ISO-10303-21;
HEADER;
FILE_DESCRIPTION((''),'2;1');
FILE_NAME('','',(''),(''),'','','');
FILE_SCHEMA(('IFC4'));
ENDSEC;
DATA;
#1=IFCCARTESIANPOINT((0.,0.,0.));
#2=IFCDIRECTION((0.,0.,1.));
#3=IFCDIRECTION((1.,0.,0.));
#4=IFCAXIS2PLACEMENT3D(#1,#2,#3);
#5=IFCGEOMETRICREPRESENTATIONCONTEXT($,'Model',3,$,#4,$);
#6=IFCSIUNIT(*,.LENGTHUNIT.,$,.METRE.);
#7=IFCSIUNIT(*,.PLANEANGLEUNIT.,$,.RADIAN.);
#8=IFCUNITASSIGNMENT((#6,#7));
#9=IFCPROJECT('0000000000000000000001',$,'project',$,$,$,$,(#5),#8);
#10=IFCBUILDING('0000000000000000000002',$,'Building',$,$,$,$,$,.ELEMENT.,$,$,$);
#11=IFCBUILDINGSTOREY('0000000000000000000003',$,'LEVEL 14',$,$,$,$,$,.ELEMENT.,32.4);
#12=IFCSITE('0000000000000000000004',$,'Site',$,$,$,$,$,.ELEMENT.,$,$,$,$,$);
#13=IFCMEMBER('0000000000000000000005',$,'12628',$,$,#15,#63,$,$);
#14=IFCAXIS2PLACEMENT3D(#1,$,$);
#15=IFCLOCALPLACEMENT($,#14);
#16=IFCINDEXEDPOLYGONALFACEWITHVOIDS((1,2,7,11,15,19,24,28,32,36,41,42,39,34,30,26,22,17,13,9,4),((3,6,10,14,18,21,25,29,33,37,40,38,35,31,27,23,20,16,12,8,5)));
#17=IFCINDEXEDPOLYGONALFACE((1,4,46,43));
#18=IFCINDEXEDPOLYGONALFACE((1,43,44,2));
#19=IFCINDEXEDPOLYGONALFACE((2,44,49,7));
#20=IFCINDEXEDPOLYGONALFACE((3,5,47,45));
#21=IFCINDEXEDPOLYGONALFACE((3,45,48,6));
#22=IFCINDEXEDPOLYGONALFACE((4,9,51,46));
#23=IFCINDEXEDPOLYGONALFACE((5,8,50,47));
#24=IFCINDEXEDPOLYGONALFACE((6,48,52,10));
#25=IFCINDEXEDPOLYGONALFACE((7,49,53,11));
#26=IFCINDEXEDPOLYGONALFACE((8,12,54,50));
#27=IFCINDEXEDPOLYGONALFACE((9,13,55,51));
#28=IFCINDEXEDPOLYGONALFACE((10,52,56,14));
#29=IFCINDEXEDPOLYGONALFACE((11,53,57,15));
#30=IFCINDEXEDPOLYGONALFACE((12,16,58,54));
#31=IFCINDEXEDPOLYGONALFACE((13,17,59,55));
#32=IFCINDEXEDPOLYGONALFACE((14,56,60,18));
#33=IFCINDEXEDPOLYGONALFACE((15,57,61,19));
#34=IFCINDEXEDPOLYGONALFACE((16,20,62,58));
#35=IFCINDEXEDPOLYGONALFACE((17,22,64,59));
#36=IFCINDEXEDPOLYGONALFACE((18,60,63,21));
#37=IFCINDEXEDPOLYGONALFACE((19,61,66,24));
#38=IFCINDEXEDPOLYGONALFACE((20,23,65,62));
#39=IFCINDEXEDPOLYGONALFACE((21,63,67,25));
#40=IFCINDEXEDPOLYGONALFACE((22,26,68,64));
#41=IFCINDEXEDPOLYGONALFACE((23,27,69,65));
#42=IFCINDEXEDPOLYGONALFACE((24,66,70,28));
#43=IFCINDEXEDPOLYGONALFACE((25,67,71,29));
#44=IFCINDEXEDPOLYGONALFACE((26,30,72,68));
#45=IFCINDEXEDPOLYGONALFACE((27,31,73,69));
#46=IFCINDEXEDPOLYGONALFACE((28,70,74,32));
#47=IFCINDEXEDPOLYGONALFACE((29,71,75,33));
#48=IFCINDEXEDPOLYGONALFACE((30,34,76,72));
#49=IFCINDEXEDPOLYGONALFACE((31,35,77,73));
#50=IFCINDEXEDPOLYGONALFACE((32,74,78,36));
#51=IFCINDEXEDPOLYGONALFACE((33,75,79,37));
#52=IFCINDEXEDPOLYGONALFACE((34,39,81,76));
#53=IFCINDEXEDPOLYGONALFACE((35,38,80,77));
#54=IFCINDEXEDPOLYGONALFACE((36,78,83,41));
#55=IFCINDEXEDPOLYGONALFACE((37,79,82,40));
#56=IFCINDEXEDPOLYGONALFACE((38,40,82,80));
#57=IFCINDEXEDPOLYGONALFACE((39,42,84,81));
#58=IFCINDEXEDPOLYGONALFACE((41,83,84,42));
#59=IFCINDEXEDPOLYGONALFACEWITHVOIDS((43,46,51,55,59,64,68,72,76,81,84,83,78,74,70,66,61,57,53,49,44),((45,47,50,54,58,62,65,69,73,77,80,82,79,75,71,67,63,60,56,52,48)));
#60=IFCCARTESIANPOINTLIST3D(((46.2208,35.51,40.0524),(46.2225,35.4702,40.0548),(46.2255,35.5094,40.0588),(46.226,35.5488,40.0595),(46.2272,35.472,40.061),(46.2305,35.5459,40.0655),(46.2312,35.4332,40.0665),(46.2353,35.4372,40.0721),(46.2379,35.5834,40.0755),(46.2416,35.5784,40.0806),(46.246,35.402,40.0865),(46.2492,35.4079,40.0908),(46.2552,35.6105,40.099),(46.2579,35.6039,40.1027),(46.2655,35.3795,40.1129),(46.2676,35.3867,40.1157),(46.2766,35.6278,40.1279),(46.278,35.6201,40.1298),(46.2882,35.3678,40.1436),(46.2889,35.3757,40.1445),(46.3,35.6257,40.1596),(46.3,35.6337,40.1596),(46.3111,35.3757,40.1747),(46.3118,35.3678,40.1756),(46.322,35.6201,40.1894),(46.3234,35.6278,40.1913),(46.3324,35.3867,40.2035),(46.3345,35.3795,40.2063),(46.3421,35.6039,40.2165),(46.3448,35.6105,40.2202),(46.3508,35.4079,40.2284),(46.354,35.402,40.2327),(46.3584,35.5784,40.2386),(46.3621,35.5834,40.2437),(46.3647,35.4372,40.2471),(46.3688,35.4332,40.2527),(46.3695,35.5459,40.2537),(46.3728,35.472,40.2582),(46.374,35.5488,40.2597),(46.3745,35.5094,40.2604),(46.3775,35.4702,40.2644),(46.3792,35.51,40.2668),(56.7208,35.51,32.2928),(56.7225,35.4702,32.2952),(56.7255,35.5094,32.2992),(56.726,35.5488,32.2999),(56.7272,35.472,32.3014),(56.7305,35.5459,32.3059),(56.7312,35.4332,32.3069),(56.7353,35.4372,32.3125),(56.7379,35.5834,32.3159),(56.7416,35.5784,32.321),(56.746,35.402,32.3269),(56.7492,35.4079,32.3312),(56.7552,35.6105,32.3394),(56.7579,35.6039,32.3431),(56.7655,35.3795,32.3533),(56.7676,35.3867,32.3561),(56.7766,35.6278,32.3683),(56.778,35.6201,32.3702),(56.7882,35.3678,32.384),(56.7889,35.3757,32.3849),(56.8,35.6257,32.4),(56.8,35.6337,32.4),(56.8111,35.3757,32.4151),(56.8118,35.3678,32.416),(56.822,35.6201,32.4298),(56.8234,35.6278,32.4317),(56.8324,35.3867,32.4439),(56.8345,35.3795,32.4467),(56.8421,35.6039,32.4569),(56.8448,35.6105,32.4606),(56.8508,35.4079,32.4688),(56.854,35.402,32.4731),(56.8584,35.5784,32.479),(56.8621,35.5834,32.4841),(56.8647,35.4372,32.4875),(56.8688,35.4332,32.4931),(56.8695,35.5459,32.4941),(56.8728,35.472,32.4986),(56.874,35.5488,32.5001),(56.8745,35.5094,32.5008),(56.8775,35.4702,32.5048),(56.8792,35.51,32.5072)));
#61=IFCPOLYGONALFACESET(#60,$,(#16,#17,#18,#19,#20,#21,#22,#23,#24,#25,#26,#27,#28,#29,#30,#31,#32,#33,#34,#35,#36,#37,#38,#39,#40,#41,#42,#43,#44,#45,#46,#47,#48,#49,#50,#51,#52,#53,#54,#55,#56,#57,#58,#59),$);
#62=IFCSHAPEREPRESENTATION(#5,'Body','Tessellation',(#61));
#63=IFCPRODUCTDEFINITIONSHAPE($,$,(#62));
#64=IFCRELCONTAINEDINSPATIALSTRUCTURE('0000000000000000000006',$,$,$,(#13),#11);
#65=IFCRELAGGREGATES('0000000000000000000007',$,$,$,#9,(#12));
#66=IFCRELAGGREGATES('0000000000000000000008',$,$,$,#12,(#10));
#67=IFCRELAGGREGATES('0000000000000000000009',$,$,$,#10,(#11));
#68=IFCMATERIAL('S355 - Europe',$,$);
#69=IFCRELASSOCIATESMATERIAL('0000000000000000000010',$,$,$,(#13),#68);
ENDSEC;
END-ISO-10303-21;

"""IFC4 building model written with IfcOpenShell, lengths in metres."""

from ifc_helpers import new_model, si_unit, frame, origin_with_axes, origin_2d_with_axis, place, context, project, spatial, hollow_circle, extrude, material, material_profile, profile_set, profile_usage, element, save


model = new_model("IFC4")

# Units and contexts
model_context = context("Model", 3, world=origin_with_axes())
ifc_project = project(units=[si_unit("LENGTHUNIT", "METRE"), si_unit("PLANEANGLEUNIT", "RADIAN")], contexts=[model_context])

# Site, building, storey
site = spatial("IfcSite", under=ifc_project, Name="Site", CompositionType="ELEMENT")
building = spatial("IfcBuilding", under=site, Name="Building", CompositionType="ELEMENT")
storey = spatial("IfcBuildingStorey", under=building, Name="LEVEL 14", CompositionType="ELEMENT", Elevation=32.4)

# Shared definitions
ifc_material = material(Name="S355 - Europe")

# Member
ifc_material_profile_1 = material_profile(ifc_material, hollow_circle(Radius=0.1337, WallThickness=0.008, at=origin_2d_with_axis()))
ifc_profile_set_1 = profile_set([ifc_material_profile_1])
ifc_profile_usage_1 = profile_usage(ifc_profile_set_1, cardinal=10)
member_1_placement = place(None, frame((46.3, 35.5, 40.1596), z_axis=(0.804223, 0.0, -0.594328), x_axis=(0.0, 1.0, 0.0)))
element("IfcMember", 1, at=member_1_placement, inside=storey, material=ifc_profile_usage_1, Name="12628", context=model_context, shape_type="SweptSolid", body=[
    extrude(hollow_circle(Radius=0.1337, WallThickness=0.008, at=origin_2d_with_axis()), origin_with_axes(), (0.0, 0.0, 1.0), 13.0561),
])

save(model, "model.ifc")
